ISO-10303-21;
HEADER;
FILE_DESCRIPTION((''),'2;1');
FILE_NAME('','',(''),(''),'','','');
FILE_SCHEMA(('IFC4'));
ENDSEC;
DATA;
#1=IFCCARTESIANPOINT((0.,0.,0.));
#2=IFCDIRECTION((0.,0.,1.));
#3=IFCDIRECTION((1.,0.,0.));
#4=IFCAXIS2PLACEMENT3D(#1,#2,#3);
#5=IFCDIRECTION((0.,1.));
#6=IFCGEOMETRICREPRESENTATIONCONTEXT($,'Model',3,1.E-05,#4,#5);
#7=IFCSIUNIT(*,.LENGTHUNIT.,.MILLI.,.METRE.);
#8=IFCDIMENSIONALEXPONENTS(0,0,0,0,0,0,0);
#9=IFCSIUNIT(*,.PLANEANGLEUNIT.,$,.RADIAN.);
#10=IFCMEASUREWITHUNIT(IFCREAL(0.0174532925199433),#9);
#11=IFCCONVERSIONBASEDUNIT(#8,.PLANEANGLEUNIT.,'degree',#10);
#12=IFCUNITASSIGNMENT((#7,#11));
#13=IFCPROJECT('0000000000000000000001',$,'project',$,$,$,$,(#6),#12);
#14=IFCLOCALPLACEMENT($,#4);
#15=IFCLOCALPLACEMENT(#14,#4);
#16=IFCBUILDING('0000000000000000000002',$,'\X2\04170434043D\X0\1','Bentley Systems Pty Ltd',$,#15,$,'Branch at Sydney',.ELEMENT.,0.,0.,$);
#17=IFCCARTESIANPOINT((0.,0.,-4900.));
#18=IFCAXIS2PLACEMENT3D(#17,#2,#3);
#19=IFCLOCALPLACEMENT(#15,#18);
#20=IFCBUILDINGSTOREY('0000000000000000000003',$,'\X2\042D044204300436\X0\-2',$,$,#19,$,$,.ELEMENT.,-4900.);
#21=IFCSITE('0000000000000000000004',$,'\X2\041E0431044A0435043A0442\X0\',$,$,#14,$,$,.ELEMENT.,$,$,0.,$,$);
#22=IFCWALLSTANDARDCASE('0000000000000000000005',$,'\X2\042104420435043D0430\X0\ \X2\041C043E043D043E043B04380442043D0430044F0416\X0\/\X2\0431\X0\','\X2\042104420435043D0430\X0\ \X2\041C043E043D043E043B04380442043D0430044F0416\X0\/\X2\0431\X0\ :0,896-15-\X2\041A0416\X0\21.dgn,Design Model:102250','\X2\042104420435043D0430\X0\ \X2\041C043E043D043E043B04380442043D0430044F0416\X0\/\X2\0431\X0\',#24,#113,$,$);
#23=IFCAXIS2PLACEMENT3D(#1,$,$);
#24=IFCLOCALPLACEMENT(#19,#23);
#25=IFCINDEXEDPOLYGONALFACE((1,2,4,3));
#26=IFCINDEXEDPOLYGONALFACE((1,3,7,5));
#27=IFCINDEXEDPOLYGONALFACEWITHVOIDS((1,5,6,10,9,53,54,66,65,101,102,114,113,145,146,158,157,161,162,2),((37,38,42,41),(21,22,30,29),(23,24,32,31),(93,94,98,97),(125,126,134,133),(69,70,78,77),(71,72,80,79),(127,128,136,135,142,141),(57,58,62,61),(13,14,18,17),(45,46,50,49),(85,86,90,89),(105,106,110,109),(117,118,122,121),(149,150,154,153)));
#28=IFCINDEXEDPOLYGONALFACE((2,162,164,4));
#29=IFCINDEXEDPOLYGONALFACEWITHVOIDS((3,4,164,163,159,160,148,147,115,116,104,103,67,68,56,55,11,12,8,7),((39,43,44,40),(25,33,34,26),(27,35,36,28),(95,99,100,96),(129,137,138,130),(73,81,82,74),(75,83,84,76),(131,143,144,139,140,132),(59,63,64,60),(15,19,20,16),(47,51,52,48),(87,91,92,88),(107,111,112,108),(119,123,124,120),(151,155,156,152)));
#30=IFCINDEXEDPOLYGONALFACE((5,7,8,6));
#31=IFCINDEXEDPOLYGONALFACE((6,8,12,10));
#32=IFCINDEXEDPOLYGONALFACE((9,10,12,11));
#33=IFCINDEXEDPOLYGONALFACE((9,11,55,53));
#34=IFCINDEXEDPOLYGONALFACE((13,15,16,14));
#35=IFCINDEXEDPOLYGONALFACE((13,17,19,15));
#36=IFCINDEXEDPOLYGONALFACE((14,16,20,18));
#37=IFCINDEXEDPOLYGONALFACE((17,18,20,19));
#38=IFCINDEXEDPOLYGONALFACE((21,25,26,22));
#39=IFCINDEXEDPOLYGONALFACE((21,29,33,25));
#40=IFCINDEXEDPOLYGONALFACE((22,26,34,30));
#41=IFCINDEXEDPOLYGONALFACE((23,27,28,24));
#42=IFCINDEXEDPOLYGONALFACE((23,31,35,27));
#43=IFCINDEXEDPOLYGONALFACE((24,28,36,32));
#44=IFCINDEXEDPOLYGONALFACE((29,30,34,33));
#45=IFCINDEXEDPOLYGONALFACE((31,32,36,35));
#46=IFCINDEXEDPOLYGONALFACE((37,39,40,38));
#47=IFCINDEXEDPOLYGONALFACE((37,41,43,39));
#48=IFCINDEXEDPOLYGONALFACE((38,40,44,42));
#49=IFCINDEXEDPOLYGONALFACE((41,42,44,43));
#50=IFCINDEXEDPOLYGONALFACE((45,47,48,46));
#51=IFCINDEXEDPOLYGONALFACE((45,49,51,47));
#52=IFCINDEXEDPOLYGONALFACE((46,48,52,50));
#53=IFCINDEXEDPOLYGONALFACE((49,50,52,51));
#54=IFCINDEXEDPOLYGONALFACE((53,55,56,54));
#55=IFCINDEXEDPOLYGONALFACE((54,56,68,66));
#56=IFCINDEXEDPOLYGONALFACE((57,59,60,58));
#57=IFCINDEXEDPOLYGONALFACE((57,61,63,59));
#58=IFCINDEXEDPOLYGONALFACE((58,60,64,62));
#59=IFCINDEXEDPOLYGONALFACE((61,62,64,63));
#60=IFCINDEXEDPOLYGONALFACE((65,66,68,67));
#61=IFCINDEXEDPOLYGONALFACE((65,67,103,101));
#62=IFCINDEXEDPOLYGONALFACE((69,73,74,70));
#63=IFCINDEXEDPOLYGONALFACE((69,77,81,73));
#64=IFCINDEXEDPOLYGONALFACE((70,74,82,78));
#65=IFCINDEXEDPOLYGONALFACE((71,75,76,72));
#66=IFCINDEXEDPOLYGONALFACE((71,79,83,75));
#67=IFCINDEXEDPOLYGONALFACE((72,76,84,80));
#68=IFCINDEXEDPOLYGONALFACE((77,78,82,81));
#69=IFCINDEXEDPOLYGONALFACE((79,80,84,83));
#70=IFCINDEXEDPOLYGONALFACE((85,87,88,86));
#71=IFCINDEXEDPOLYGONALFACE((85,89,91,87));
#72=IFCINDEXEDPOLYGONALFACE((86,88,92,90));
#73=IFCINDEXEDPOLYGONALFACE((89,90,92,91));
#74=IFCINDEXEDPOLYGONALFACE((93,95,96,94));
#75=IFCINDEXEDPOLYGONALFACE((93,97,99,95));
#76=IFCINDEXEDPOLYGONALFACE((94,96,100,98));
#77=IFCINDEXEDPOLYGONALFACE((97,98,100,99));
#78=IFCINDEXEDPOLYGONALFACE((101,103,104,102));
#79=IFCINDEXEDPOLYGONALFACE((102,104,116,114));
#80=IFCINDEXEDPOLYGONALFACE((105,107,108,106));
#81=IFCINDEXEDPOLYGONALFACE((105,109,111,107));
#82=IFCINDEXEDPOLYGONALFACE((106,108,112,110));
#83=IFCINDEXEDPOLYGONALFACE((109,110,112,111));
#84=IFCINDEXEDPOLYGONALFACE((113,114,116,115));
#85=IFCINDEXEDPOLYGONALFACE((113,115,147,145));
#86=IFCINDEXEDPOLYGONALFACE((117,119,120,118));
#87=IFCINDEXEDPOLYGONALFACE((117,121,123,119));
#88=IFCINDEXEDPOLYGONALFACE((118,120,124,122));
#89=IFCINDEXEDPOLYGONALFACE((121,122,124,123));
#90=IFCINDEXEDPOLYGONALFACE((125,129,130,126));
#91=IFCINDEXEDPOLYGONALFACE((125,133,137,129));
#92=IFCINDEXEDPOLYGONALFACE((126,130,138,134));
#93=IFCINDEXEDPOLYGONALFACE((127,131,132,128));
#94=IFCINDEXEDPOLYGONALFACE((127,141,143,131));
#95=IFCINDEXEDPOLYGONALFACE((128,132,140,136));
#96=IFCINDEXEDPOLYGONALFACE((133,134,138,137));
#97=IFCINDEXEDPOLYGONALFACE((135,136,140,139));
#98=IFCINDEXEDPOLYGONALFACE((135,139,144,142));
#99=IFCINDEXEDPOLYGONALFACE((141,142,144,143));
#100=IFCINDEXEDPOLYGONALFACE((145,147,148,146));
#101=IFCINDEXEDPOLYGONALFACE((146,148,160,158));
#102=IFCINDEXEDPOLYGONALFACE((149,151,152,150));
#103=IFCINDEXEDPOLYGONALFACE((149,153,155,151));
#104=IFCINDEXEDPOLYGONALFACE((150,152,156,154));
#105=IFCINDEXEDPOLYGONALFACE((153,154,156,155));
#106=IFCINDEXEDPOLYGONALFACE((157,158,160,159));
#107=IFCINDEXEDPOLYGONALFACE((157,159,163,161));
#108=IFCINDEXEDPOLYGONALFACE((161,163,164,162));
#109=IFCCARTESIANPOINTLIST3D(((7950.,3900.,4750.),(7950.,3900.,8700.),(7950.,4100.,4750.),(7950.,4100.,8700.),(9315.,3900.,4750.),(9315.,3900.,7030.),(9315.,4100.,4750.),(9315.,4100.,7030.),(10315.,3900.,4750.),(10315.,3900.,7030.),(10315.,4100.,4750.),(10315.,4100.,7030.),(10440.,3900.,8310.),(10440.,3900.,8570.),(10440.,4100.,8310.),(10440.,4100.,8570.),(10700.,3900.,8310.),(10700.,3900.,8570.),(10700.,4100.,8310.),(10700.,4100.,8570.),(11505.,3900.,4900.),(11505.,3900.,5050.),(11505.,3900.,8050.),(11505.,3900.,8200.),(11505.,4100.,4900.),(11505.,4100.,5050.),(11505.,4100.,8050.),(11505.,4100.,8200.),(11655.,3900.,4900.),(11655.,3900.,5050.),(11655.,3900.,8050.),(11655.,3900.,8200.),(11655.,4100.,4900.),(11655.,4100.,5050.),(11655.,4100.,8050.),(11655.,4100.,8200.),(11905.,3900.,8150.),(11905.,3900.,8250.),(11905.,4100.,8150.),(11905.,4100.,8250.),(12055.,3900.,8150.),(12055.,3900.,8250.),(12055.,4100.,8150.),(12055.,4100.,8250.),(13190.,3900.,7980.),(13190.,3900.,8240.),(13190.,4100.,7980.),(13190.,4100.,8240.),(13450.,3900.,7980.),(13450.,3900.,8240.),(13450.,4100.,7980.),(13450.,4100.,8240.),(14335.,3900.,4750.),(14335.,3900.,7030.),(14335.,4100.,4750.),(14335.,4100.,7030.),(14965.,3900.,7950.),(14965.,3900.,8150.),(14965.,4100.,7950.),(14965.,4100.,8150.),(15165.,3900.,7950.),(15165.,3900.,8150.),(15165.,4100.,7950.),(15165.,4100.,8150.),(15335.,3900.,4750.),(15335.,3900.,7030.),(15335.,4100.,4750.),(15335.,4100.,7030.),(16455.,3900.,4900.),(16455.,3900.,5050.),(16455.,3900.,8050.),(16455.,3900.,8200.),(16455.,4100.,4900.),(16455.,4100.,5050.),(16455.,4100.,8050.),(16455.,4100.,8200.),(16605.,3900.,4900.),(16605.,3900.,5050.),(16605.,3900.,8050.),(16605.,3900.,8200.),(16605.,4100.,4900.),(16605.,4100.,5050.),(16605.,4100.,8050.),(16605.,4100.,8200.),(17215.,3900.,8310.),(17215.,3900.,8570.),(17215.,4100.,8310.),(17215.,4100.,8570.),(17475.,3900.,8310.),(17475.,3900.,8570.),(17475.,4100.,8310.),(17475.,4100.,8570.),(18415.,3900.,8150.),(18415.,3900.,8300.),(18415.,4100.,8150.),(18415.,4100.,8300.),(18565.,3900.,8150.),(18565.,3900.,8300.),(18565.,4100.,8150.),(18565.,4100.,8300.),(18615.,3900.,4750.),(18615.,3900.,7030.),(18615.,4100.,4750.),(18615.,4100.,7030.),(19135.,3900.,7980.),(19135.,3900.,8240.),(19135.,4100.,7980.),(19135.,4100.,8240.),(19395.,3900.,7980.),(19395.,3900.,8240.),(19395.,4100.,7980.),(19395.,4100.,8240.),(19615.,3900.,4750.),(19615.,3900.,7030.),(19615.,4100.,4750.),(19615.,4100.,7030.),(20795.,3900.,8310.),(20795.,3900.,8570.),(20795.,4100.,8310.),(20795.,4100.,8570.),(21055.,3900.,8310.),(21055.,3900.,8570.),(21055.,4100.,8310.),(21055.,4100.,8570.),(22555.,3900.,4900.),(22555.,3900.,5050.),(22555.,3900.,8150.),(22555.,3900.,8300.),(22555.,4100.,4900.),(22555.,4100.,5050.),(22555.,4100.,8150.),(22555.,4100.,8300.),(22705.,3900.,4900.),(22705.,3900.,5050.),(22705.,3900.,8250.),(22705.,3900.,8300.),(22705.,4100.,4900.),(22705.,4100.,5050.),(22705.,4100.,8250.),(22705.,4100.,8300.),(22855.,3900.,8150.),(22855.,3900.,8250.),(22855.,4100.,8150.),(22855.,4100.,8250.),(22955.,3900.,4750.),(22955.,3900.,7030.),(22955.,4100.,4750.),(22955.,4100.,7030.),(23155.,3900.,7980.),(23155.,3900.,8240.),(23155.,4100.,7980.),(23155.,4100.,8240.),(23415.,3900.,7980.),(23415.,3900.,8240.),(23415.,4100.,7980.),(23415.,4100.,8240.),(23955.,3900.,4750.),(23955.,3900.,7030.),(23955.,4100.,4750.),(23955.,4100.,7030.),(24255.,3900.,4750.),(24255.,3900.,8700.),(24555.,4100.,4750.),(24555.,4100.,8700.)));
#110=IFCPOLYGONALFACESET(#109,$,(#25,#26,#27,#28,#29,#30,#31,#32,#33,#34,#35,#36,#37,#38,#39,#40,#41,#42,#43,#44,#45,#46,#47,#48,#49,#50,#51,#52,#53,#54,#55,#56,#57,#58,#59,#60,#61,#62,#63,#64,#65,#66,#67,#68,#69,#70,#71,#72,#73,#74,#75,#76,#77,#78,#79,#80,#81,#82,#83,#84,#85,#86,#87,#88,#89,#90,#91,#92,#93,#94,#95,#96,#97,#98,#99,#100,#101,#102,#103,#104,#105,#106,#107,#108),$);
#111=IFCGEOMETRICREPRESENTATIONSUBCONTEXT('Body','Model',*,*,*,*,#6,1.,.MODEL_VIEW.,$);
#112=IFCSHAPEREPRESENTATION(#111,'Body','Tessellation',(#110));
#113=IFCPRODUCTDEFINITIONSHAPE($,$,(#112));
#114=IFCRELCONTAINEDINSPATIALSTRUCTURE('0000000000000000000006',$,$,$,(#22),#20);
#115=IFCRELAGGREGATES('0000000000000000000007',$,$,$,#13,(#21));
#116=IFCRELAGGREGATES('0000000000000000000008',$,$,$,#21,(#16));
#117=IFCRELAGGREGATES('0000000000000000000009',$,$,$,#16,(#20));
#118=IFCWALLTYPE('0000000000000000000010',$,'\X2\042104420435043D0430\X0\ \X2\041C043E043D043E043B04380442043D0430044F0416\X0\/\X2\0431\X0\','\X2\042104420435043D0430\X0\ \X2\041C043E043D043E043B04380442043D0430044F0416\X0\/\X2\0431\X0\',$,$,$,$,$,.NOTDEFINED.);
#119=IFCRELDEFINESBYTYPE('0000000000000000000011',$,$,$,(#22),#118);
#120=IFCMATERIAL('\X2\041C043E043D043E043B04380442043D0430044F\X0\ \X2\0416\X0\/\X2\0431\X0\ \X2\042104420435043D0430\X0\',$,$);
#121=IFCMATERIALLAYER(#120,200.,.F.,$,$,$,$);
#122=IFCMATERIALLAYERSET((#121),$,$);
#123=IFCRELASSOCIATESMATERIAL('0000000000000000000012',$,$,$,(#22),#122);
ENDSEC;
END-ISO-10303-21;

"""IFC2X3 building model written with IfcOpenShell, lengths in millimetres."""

from ifc_helpers import new_model, entity, si_unit, converted_unit, direction, frame, frame_2d, origin_with_axes, place, context, subcontext, project, spatial, polyline, rectangle, outline, extrude, material, layer, layer_set, layer_usage, type_object, element, save


model = new_model("IFC2X3")

# Units and contexts
model_context = context("Model", 3, precision=1e-05, world=origin_with_axes(), true_north=direction((0.0, 1.0)))
body_context = subcontext(model_context, "Body", "Model", "MODEL_VIEW", scale=1.0)
ifc_project = project(units=[si_unit("LENGTHUNIT", "METRE", prefix="MILLI"), converted_unit("PLANEANGLEUNIT", "degree", entity("IfcReal", 0.0174532925199433), si_unit("PLANEANGLEUNIT", "RADIAN"), dimensions=[0, 0, 0, 0, 0, 0, 0])], contexts=[model_context])

# Site, building, storey
site_placement = place(None, origin_with_axes())
site = spatial("IfcSite", under=ifc_project, at=site_placement, Name="Объект", CompositionType="ELEMENT", RefElevation=0.0)
building_placement = place(site_placement, origin_with_axes())
building = spatial("IfcBuilding", under=site, at=building_placement, Name="Здн1", Description="Bentley Systems Pty Ltd", LongName="Branch at Sydney", CompositionType="ELEMENT", ElevationOfRefHeight=0.0, ElevationOfTerrain=0.0)
storey_placement = place(building_placement, frame((0.0, 0.0, -4900.0), z_axis=(0.0, 0.0, 1.0), x_axis=(1.0, 0.0, 0.0)))
storey = spatial("IfcBuildingStorey", under=building, at=storey_placement, Name="Этаж-2", CompositionType="ELEMENT", Elevation=-4900.0)

# Wall, openings
ifc_material = material(Name="Монолитная Ж/б Стена")
wall_type = type_object("IfcWallType", Name="Стена МонолитнаяЖ/б", Description="Стена МонолитнаяЖ/б", PredefinedType="NOTDEFINED")
ifc_layer_1 = layer(ifc_material, 200.0, ventilated=False)
ifc_layer_set_1 = layer_set([ifc_layer_1])
ifc_layer_usage_1 = layer_usage(ifc_layer_set_1, "AXIS2", "POSITIVE", 0.0)
wall_1_placement = place(storey_placement, frame((7950.0, 3900.0, 4750.0), z_axis=(0.0, 0.0, 1.0), x_axis=(1.0, 0.0, 0.0)))
wall_1 = element("IfcWallStandardCase", 1, at=wall_1_placement, inside=storey, type_object=wall_type, material=ifc_layer_usage_1, Name="Стена МонолитнаяЖ/б", Description="Стена МонолитнаяЖ/б :0,896-15-КЖ21.dgn,Design Model:102250", ObjectType="Стена МонолитнаяЖ/б", context=body_context, shape_type="SweptSolid", body=[
    extrude(outline(polyline([(16605.0, 200.0), (0.0, 200.0), (0.0, 0.0), (16305.0, 0.0), (16605.0, 200.0)])), origin_with_axes(), (0.0, 0.0, 1.0), 3950.0),
])
opening_1_placement = place(wall_1_placement, frame((1365.0, 0.0, 0.0), z_axis=(0.0, 0.0, 1.0), x_axis=(1.0, 0.0, 0.0)))
element("IfcOpeningElement", 2, at=opening_1_placement, cuts=wall_1, ObjectType="Opening", context=body_context, shape_type="SweptSolid", body=[
    extrude(rectangle(XDim=2280.0, YDim=1000.0, at=frame_2d((-500.0, 1140.0), x_axis=(0.0, -1.0))), frame((0.0, 0.0, 0.0), z_axis=(0.0, 1.0, 0.0), x_axis=(-1.0, 0.0, 0.0)), (0.0, 0.0, 1.0), 200.0),
])
opening_2_placement = place(wall_1_placement, frame((6385.0, 0.0, 0.0), z_axis=(0.0, 0.0, 1.0), x_axis=(1.0, 0.0, 0.0)))
element("IfcOpeningElement", 3, at=opening_2_placement, cuts=wall_1, ObjectType="Opening", context=body_context, shape_type="SweptSolid", body=[
    extrude(rectangle(XDim=2280.0, YDim=1000.0, at=frame_2d((-500.0, 1140.0), x_axis=(0.0, -1.0))), frame((0.0, 0.0, 0.0), z_axis=(0.0, 1.0, 0.0), x_axis=(-1.0, 0.0, 0.0)), (0.0, 0.0, 1.0), 200.0),
])
opening_3_placement = place(wall_1_placement, frame((10665.0, 0.0, 0.0), z_axis=(0.0, 0.0, 1.0), x_axis=(1.0, 0.0, 0.0)))
element("IfcOpeningElement", 4, at=opening_3_placement, cuts=wall_1, ObjectType="Opening", context=body_context, shape_type="SweptSolid", body=[
    extrude(rectangle(XDim=2280.0, YDim=1000.0, at=frame_2d((-500.0, 1140.0), x_axis=(0.0, -1.0))), frame((0.0, 0.0, 0.0), z_axis=(0.0, 1.0, 0.0), x_axis=(-1.0, 0.0, 0.0)), (0.0, 0.0, 1.0), 200.0),
])
opening_4_placement = place(wall_1_placement, frame((15005.0, 0.0, 0.0), z_axis=(0.0, 0.0, 1.0), x_axis=(1.0, 0.0, 0.0)))
element("IfcOpeningElement", 5, at=opening_4_placement, cuts=wall_1, ObjectType="Opening", context=body_context, shape_type="SweptSolid", body=[
    extrude(rectangle(XDim=2280.0, YDim=1000.0, at=frame_2d((-500.0, 1140.0), x_axis=(0.0, -1.0))), frame((0.0, 0.0, 0.0), z_axis=(0.0, 1.0, 0.0), x_axis=(-1.0, 0.0, 0.0)), (0.0, 0.0, 1.0), 200.0),
])
opening_5_placement = place(wall_1_placement, frame((7015.0, 0.0, 3200.0), z_axis=(0.0, 0.0, 1.0), x_axis=(1.0, 0.0, 0.0)))
element("IfcOpeningElement", 6, at=opening_5_placement, cuts=wall_1, ObjectType="Opening", context=body_context, shape_type="SweptSolid", body=[
    extrude(rectangle(XDim=200.0, YDim=200.0, at=frame_2d((-100.0, 100.0), x_axis=(0.0, -1.0))), frame((0.0, 0.0, 0.0), z_axis=(0.0, 1.0, 0.0), x_axis=(-1.0, 0.0, 0.0)), (0.0, 0.0, 1.0), 200.0),
])
opening_6_placement = place(wall_1_placement, frame((8505.0, 0.0, 150.0), z_axis=(0.0, 0.0, 1.0), x_axis=(1.0, 0.0, 0.0)))
element("IfcOpeningElement", 7, at=opening_6_placement, cuts=wall_1, ObjectType="Opening", context=body_context, shape_type="SweptSolid", body=[
    extrude(rectangle(XDim=150.0, YDim=150.0, at=frame_2d((-75.0, 75.0), x_axis=(0.0, -1.0))), frame((0.0, 0.0, 0.0), z_axis=(0.0, 1.0, 0.0), x_axis=(-1.0, 0.0, 0.0)), (0.0, 0.0, 1.0), 200.0),
])
opening_7_placement = place(wall_1_placement, frame((8505.0, 0.0, 3300.0), z_axis=(0.0, 0.0, 1.0), x_axis=(1.0, 0.0, 0.0)))
element("IfcOpeningElement", 8, at=opening_7_placement, cuts=wall_1, ObjectType="Opening", context=body_context, shape_type="SweptSolid", body=[
    extrude(rectangle(XDim=150.0, YDim=150.0, at=frame_2d((-75.0, 75.0), x_axis=(0.0, -1.0))), frame((0.0, 0.0, 0.0), z_axis=(0.0, 1.0, 0.0), x_axis=(-1.0, 0.0, 0.0)), (0.0, 0.0, 1.0), 200.0),
])
opening_8_placement = place(wall_1_placement, frame((9265.0, 0.0, 3560.0), z_axis=(0.0, 0.0, 1.0), x_axis=(1.0, 0.0, 0.0)))
element("IfcOpeningElement", 9, at=opening_8_placement, cuts=wall_1, ObjectType="Opening", context=body_context, shape_type="SweptSolid", body=[
    extrude(rectangle(XDim=260.0, YDim=260.0, at=frame_2d((-130.0, 130.0), x_axis=(0.0, -1.0))), frame((0.0, 0.0, 0.0), z_axis=(0.0, 1.0, 0.0), x_axis=(-1.0, 0.0, 0.0)), (0.0, 0.0, 1.0), 200.0),
])
opening_9_placement = place(wall_1_placement, frame((10465.0, 0.0, 3400.0), z_axis=(0.0, 0.0, 1.0), x_axis=(1.0, 0.0, 0.0)))
element("IfcOpeningElement", 10, at=opening_9_placement, cuts=wall_1, ObjectType="Opening", context=body_context, shape_type="SweptSolid", body=[
    extrude(rectangle(XDim=150.0, YDim=150.0, at=frame_2d((-75.0, 75.0), x_axis=(0.0, -1.0))), frame((0.0, 0.0, 0.0), z_axis=(0.0, 1.0, 0.0), x_axis=(-1.0, 0.0, 0.0)), (0.0, 0.0, 1.0), 200.0),
])
opening_10_placement = place(wall_1_placement, frame((11185.0, 0.0, 3230.0), z_axis=(0.0, 0.0, 1.0), x_axis=(1.0, 0.0, 0.0)))
element("IfcOpeningElement", 11, at=opening_10_placement, cuts=wall_1, ObjectType="Opening", context=body_context, shape_type="SweptSolid", body=[
    extrude(rectangle(XDim=260.0, YDim=260.0, at=frame_2d((-130.0, 130.0), x_axis=(0.0, -1.0))), frame((0.0, 0.0, 0.0), z_axis=(0.0, 1.0, 0.0), x_axis=(-1.0, 0.0, 0.0)), (0.0, 0.0, 1.0), 200.0),
])
opening_11_placement = place(wall_1_placement, frame((12845.0, 0.0, 3560.0), z_axis=(0.0, 0.0, 1.0), x_axis=(1.0, 0.0, 0.0)))
element("IfcOpeningElement", 12, at=opening_11_placement, cuts=wall_1, ObjectType="Opening", context=body_context, shape_type="SweptSolid", body=[
    extrude(rectangle(XDim=260.0, YDim=260.0, at=frame_2d((-130.0, 130.0), x_axis=(0.0, -1.0))), frame((0.0, 0.0, 0.0), z_axis=(0.0, 1.0, 0.0), x_axis=(-1.0, 0.0, 0.0)), (0.0, 0.0, 1.0), 200.0),
])
opening_12_placement = place(wall_1_placement, frame((15205.0, 0.0, 3230.0), z_axis=(0.0, 0.0, 1.0), x_axis=(1.0, 0.0, 0.0)))
element("IfcOpeningElement", 13, at=opening_12_placement, cuts=wall_1, ObjectType="Opening", context=body_context, shape_type="SweptSolid", body=[
    extrude(rectangle(XDim=260.0, YDim=260.0, at=frame_2d((-130.0, 130.0), x_axis=(0.0, -1.0))), frame((0.0, 0.0, 0.0), z_axis=(0.0, 1.0, 0.0), x_axis=(-1.0, 0.0, 0.0)), (0.0, 0.0, 1.0), 200.0),
])
opening_13_placement = place(wall_1_placement, frame((14605.0, 0.0, 150.0), z_axis=(0.0, 0.0, 1.0), x_axis=(1.0, 0.0, 0.0)))
element("IfcOpeningElement", 14, at=opening_13_placement, cuts=wall_1, ObjectType="Opening", context=body_context, shape_type="SweptSolid", body=[
    extrude(rectangle(XDim=150.0, YDim=150.0, at=frame_2d((-75.0, 75.0), x_axis=(0.0, -1.0))), frame((0.0, 0.0, 0.0), z_axis=(0.0, 1.0, 0.0), x_axis=(-1.0, 0.0, 0.0)), (0.0, 0.0, 1.0), 200.0),
])
opening_14_placement = place(wall_1_placement, frame((14605.0, 0.0, 3400.0), z_axis=(0.0, 0.0, 1.0), x_axis=(1.0, 0.0, 0.0)))
element("IfcOpeningElement", 15, at=opening_14_placement, cuts=wall_1, ObjectType="Opening", context=body_context, shape_type="SweptSolid", body=[
    extrude(outline(polyline([(-150.0, 150.0), (0.0, 150.0), (0.0, 0.0), (-300.0, 0.0), (-300.0, 100.0), (-150.0, 100.0), (-150.0, 150.0)])), frame((0.0, 0.0, 0.0), z_axis=(0.0, 1.0, 0.0), x_axis=(-1.0, 0.0, 0.0)), (0.0, 0.0, 1.0), 200.0),
])
opening_15_placement = place(wall_1_placement, frame((2490.0, 0.0, 3560.0), z_axis=(0.0, 0.0, 1.0), x_axis=(1.0, 0.0, 0.0)))
element("IfcOpeningElement", 16, at=opening_15_placement, cuts=wall_1, ObjectType="Opening", context=body_context, shape_type="SweptSolid", body=[
    extrude(rectangle(XDim=260.0, YDim=260.0, at=frame_2d((-130.0, 130.0), x_axis=(0.0, -1.0))), frame((0.0, 0.0, 0.0), z_axis=(0.0, 1.0, 0.0), x_axis=(-1.0, 0.0, 0.0)), (0.0, 0.0, 1.0), 200.0),
])
opening_16_placement = place(wall_1_placement, frame((3555.0, 0.0, 3300.0), z_axis=(0.0, 0.0, 1.0), x_axis=(1.0, 0.0, 0.0)))
element("IfcOpeningElement", 17, at=opening_16_placement, cuts=wall_1, ObjectType="Opening", context=body_context, shape_type="SweptSolid", body=[
    extrude(rectangle(XDim=150.0, YDim=150.0, at=frame_2d((-75.0, 75.0), x_axis=(0.0, -1.0))), frame((0.0, 0.0, 0.0), z_axis=(0.0, 1.0, 0.0), x_axis=(-1.0, 0.0, 0.0)), (0.0, 0.0, 1.0), 200.0),
])
opening_17_placement = place(wall_1_placement, frame((3955.0, 0.0, 3400.0), z_axis=(0.0, 0.0, 1.0), x_axis=(1.0, 0.0, 0.0)))
element("IfcOpeningElement", 18, at=opening_17_placement, cuts=wall_1, ObjectType="Opening", context=body_context, shape_type="SweptSolid", body=[
    extrude(rectangle(XDim=100.0, YDim=150.0, at=frame_2d((-75.0, 50.0), x_axis=(0.0, -1.0))), frame((0.0, 0.0, 0.0), z_axis=(0.0, 1.0, 0.0), x_axis=(-1.0, 0.0, 0.0)), (0.0, 0.0, 1.0), 200.0),
])
opening_18_placement = place(wall_1_placement, frame((3555.0, 0.0, 150.0), z_axis=(0.0, 0.0, 1.0), x_axis=(1.0, 0.0, 0.0)))
element("IfcOpeningElement", 19, at=opening_18_placement, cuts=wall_1, ObjectType="Opening", context=body_context, shape_type="SweptSolid", body=[
    extrude(rectangle(XDim=150.0, YDim=150.0, at=frame_2d((-75.0, 75.0), x_axis=(0.0, -1.0))), frame((0.0, 0.0, 0.0), z_axis=(0.0, 1.0, 0.0), x_axis=(-1.0, 0.0, 0.0)), (0.0, 0.0, 1.0), 200.0),
])
opening_19_placement = place(wall_1_placement, frame((5240.0, 0.0, 3230.0), z_axis=(0.0, 0.0, 1.0), x_axis=(1.0, 0.0, 0.0)))
element("IfcOpeningElement", 20, at=opening_19_placement, cuts=wall_1, ObjectType="Opening", context=body_context, shape_type="SweptSolid", body=[
    extrude(rectangle(XDim=260.0, YDim=260.0, at=frame_2d((-130.0, 130.0), x_axis=(0.0, -1.0))), frame((0.0, 0.0, 0.0), z_axis=(0.0, 1.0, 0.0), x_axis=(-1.0, 0.0, 0.0)), (0.0, 0.0, 1.0), 200.0),
])

save(model, "model.ifc")
